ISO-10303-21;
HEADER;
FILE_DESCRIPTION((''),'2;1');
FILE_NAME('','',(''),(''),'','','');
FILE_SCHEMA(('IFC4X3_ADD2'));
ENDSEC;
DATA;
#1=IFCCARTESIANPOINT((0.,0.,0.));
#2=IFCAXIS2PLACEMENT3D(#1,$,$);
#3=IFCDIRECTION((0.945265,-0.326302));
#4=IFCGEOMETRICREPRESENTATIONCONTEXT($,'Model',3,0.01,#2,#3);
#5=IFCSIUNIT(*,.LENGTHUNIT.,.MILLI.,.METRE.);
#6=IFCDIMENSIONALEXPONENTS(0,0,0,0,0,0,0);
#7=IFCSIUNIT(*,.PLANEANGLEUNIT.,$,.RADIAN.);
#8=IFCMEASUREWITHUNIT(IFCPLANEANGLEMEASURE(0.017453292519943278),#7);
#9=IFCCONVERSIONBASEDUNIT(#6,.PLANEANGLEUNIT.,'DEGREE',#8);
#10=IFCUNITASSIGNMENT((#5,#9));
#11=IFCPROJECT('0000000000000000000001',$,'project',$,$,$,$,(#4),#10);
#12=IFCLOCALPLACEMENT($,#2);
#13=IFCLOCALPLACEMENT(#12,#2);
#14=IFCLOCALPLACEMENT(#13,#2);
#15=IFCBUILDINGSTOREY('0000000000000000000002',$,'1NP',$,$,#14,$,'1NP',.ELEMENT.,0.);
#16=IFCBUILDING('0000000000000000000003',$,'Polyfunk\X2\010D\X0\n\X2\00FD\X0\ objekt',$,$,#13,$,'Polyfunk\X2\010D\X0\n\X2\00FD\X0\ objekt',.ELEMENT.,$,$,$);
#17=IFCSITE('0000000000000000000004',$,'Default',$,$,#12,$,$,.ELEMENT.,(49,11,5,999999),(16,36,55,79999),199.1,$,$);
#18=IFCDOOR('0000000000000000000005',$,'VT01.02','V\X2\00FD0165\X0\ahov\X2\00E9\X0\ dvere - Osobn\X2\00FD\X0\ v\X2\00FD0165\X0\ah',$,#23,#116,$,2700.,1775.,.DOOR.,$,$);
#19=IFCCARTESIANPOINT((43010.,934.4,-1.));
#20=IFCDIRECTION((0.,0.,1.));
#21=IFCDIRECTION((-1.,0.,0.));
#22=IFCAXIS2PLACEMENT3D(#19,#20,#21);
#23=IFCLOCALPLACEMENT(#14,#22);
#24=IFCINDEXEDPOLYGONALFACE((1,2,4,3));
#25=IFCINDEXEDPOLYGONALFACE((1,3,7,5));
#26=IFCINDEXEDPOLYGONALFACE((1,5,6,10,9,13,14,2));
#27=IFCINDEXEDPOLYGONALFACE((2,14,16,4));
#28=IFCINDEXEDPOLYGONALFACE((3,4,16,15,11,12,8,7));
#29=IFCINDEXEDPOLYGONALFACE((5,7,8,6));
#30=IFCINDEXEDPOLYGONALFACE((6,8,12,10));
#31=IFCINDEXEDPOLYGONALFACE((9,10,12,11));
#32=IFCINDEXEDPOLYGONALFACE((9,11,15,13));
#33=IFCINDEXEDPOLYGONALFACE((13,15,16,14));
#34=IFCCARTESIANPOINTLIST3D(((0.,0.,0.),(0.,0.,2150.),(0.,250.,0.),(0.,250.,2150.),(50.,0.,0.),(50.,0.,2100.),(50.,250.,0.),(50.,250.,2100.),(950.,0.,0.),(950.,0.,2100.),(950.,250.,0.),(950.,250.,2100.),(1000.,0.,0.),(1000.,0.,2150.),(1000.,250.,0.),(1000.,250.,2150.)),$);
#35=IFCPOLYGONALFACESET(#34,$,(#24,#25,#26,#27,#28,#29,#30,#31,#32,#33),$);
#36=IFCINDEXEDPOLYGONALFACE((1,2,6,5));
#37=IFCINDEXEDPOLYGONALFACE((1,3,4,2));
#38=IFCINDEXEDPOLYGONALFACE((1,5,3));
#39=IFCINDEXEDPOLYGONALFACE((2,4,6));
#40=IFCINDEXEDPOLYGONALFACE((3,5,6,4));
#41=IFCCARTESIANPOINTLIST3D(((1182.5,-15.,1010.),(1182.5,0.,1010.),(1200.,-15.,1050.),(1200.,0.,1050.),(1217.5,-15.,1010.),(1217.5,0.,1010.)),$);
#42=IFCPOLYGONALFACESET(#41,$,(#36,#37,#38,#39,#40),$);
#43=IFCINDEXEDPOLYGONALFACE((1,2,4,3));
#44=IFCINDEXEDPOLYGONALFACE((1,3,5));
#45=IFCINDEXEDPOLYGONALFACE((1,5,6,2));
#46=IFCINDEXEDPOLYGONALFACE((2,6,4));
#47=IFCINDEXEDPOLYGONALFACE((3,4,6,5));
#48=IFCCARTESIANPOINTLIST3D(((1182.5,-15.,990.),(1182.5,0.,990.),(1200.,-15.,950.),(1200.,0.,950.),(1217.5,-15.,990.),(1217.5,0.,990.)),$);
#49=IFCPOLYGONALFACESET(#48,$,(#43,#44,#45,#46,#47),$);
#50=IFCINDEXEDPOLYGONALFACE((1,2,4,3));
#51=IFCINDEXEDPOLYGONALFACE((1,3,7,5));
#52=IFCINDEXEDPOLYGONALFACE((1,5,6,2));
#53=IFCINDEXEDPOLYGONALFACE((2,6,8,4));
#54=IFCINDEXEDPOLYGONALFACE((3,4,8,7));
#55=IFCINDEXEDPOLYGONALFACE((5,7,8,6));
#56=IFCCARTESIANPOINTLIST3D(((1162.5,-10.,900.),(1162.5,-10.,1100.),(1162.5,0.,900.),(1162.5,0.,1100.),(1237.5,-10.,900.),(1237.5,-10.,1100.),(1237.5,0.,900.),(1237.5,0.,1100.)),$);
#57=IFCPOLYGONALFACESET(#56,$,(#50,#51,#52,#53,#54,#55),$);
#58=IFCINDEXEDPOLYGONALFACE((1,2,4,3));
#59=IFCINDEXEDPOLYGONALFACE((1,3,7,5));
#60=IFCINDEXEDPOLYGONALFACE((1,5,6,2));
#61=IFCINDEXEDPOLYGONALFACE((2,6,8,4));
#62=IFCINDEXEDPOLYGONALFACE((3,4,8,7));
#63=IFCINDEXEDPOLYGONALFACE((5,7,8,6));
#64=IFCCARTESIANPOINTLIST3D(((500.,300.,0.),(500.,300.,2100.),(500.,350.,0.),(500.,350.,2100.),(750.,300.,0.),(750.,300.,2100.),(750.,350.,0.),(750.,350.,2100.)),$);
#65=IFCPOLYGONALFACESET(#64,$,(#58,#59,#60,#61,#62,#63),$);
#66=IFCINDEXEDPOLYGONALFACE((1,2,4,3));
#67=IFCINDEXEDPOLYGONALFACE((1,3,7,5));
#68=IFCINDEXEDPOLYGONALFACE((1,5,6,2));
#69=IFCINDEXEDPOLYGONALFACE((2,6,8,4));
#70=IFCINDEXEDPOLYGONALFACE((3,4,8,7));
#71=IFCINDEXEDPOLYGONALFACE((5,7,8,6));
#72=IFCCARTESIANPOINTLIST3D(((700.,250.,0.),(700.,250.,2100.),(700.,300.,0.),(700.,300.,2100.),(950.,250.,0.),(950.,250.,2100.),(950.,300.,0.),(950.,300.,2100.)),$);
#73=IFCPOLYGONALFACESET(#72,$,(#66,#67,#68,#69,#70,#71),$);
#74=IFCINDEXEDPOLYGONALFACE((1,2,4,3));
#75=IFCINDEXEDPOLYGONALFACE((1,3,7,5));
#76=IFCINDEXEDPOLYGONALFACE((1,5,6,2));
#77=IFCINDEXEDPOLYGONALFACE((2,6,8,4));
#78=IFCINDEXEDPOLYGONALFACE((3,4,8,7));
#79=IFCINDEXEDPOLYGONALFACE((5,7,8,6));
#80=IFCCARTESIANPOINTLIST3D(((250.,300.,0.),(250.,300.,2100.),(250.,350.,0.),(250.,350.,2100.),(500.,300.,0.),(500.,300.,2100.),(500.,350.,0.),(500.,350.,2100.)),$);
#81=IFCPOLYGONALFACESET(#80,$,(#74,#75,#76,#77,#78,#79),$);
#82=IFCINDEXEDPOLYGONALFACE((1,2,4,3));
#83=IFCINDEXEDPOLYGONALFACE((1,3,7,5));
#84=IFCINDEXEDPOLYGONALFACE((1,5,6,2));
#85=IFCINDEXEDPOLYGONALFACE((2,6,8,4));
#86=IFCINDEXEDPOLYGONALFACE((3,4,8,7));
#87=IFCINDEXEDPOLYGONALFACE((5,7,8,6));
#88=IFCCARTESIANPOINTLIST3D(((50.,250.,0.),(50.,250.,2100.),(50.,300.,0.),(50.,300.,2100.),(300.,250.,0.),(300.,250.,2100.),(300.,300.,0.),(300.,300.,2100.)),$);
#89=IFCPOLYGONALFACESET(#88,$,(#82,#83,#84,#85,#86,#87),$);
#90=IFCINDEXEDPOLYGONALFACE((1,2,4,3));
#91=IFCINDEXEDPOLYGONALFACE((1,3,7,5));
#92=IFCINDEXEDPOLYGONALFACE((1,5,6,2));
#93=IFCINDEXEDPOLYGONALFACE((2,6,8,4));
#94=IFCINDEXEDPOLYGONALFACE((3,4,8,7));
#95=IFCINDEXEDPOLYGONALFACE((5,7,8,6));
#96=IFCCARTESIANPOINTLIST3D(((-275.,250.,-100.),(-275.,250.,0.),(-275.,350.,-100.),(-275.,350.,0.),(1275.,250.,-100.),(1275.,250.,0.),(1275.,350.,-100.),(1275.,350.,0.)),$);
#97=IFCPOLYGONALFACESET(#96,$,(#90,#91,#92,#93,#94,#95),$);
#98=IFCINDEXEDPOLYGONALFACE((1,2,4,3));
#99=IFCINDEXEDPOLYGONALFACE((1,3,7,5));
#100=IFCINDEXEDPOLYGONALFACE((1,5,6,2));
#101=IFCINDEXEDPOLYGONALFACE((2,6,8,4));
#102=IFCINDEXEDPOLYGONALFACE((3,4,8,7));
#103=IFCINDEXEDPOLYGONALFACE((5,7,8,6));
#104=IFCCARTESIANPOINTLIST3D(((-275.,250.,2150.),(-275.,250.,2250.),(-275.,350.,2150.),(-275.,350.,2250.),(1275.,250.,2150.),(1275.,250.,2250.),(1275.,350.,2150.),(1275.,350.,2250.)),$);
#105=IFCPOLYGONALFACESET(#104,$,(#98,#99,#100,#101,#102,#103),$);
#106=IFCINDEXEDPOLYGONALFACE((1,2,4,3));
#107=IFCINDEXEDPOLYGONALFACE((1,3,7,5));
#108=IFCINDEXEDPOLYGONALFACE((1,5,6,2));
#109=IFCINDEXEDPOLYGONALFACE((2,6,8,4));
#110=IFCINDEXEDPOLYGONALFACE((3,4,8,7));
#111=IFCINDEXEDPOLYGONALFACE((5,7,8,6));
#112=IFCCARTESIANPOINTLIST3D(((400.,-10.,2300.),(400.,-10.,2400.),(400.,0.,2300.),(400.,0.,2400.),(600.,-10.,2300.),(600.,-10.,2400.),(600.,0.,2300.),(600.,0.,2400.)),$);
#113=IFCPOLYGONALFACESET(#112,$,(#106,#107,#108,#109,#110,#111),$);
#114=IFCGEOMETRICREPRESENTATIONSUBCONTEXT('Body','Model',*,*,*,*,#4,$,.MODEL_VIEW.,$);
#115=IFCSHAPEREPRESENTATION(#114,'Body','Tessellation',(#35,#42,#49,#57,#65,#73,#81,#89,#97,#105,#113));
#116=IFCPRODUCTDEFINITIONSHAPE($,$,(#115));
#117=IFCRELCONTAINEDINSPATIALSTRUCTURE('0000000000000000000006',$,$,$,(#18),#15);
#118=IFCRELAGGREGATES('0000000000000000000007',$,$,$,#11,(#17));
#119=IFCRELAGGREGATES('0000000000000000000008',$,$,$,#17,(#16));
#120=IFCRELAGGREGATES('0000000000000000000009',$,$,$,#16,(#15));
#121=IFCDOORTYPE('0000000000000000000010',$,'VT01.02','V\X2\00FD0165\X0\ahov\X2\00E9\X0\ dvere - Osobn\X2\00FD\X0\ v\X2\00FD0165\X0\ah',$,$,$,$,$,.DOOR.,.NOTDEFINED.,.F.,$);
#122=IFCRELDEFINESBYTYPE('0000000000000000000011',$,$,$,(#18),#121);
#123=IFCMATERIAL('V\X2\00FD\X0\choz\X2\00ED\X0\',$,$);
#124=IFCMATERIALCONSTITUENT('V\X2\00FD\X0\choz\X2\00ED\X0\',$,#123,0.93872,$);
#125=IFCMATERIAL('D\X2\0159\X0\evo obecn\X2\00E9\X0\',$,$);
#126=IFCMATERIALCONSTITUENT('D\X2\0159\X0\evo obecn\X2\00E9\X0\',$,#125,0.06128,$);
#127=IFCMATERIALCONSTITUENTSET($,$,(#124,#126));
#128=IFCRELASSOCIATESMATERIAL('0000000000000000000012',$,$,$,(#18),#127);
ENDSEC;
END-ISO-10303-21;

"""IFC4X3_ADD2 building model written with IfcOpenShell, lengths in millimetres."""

from ifc_helpers import new_model, entity, si_unit, converted_unit, direction, frame, frame_2d, origin, origin_2d_with_axis, place, context, subcontext, project, spatial, polyline, rectangle, outline, extrude, source, transform, mapped, material, constituent, constituent_set, type_object, type_shapes, element, save


model = new_model("IFC4X3_ADD2")

# Units and contexts
model_context = context("Model", 3, precision=0.01, world=origin(), true_north=direction((0.945265, -0.326302)))
body_context = subcontext(model_context, "Body", "Model", "MODEL_VIEW")
ifc_project = project(units=[si_unit("LENGTHUNIT", "METRE", prefix="MILLI"), converted_unit("PLANEANGLEUNIT", "DEGREE", entity("IfcPlaneAngleMeasure", 0.017453292519943278), si_unit("PLANEANGLEUNIT", "RADIAN"), dimensions=[0, 0, 0, 0, 0, 0, 0])], contexts=[model_context])

# Site, building, storey
site_placement = place(None, origin())
site = spatial("IfcSite", under=ifc_project, at=site_placement, Name="Default", CompositionType="ELEMENT", RefLatitude=(49, 11, 5, 999999), RefLongitude=(16, 36, 55, 79999), RefElevation=199.1)
building_placement = place(site_placement, origin())
building = spatial("IfcBuilding", under=site, at=building_placement, Name="Polyfunkčný objekt", LongName="Polyfunkčný objekt", CompositionType="ELEMENT")
storey_placement = place(building_placement, origin())
storey = spatial("IfcBuildingStorey", under=building, at=storey_placement, Name="1NP", LongName="1NP", CompositionType="ELEMENT", Elevation=0.0)

# Door
ifc_material_1 = material(Name="Výchozí")
ifc_constituent_1 = constituent(ifc_material_1, Name="Výchozí", fraction=0.93872)
ifc_material_2 = material(Name="Dřevo obecné")
ifc_constituent_2 = constituent(ifc_material_2, Name="Dřevo obecné", fraction=0.06128)
ifc_constituent_set_1 = constituent_set(constituents=[ifc_constituent_1, ifc_constituent_2])
door_type_1 = type_object("IfcDoorType", Name="VT01.02", Description="Výťahové dvere - Osobný výťah", OperationType="NOTDEFINED", ParameterTakesPrecedence=False, PredefinedType="DOOR")
shared_shape_1 = source(origin(), body_context, "Body", "SweptSolid", [
    extrude(outline(polyline([(-1087.5, -500.0), (1062.5, -500.0), (1062.5, -450.0), (-1037.5, -450.0), (-1037.5, 450.0), (1062.5, 450.0), (1062.5, 500.0), (-1087.5, 500.0), (-1087.5, -500.0)])), frame((500.0, 0.0, 1062.5), z_axis=(0.0, 1.0, 0.0), x_axis=(0.0, 0.0, -1.0)), (0.0, 0.0, 1.0), 250.0),
    extrude(outline(polyline([(-24.4, -10.7), (19.2, -10.7), (5.2, 21.4), (-24.4, -10.7)])), frame((1200.0, -15.0, 1023.3), z_axis=(0.0, 1.0, 0.0), x_axis=(0.400819, 0.0, -0.916157)), (0.0, 0.0, 1.0), 15.0),
    extrude(outline(polyline([(-24.4, -10.7), (19.2, -10.7), (5.2, 21.4), (-24.4, -10.7)])), frame((1200.0, -15.0, 976.7), z_axis=(0.0, 1.0, 0.0), x_axis=(-0.400819, 0.0, 0.916157)), (0.0, 0.0, 1.0), 15.0),
    extrude(rectangle(XDim=10.0, YDim=75.0, at=frame_2d((0.0, 0.0), x_axis=(1.0, 0.0))), frame((1200.0, -5.0, 900.0), z_axis=(0.0, 0.0, 1.0), x_axis=(0.0, 1.0, 0.0)), (0.0, 0.0, 1.0), 200.0),
    extrude(rectangle(XDim=50.0, YDim=250.0, at=origin_2d_with_axis()), frame((625.0, 325.0, 0.0), z_axis=(0.0, 0.0, 1.0), x_axis=(0.0, -1.0, 0.0)), (0.0, 0.0, 1.0), 2100.0),
    extrude(rectangle(XDim=50.0, YDim=250.0, at=frame_2d((0.0, 0.0), x_axis=(1.0, 0.0))), frame((825.0, 275.0, 0.0), z_axis=(0.0, 0.0, 1.0), x_axis=(0.0, -1.0, 0.0)), (0.0, 0.0, 1.0), 2100.0),
    extrude(rectangle(XDim=250.0, YDim=50.0, at=frame_2d((0.0, 0.0), x_axis=(1.0, 0.0))), frame((375.0, 325.0, 0.0), z_axis=(0.0, 0.0, 1.0), x_axis=(-1.0, 0.0, 0.0)), (0.0, 0.0, 1.0), 2100.0),
    extrude(rectangle(XDim=250.0, YDim=50.0, at=frame_2d((0.0, 0.0), x_axis=(1.0, 0.0))), frame((175.0, 275.0, 0.0), z_axis=(0.0, 0.0, 1.0), x_axis=(-1.0, 0.0, 0.0)), (0.0, 0.0, 1.0), 2100.0),
    extrude(rectangle(XDim=1550.0, YDim=100.0, at=frame_2d((0.0, 0.0), x_axis=(1.0, 0.0))), frame((500.0, 300.0, -100.0), z_axis=(0.0, 0.0, 1.0), x_axis=(-1.0, 0.0, 0.0)), (0.0, 0.0, 1.0), 100.0),
    extrude(rectangle(XDim=1550.0, YDim=100.0, at=frame_2d((0.0, 0.0), x_axis=(1.0, 0.0))), frame((500.0, 300.0, 2150.0), z_axis=(0.0, 0.0, 1.0), x_axis=(-1.0, 0.0, 0.0)), (0.0, 0.0, 1.0), 100.0),
    extrude(rectangle(XDim=10.0, YDim=200.0, at=frame_2d((0.0, 0.0), x_axis=(1.0, 0.0))), frame((500.0, -5.0, 2300.0), z_axis=(0.0, 0.0, 1.0), x_axis=(0.0, 1.0, 0.0)), (0.0, 0.0, 1.0), 100.0),
])
type_shapes(door_type_1, [shared_shape_1])
door_1_placement = place(storey_placement, frame((43010.0, 934.4, -1.0), z_axis=(0.0, 0.0, 1.0), x_axis=(-1.0, 0.0, 0.0)))
element("IfcDoor", 1, at=door_1_placement, inside=storey, type_object=door_type_1, material=ifc_constituent_set_1, Name="VT01.02", Description="Výťahové dvere - Osobný výťah", OverallHeight=2700.0, OverallWidth=1775.0, PredefinedType="DOOR", context=body_context, shape_type="MappedRepresentation", body=[
    mapped(shared_shape_1, transform((0.0, 0.0, 0.0), scale=1.0)),
])

save(model, "model.ifc")
